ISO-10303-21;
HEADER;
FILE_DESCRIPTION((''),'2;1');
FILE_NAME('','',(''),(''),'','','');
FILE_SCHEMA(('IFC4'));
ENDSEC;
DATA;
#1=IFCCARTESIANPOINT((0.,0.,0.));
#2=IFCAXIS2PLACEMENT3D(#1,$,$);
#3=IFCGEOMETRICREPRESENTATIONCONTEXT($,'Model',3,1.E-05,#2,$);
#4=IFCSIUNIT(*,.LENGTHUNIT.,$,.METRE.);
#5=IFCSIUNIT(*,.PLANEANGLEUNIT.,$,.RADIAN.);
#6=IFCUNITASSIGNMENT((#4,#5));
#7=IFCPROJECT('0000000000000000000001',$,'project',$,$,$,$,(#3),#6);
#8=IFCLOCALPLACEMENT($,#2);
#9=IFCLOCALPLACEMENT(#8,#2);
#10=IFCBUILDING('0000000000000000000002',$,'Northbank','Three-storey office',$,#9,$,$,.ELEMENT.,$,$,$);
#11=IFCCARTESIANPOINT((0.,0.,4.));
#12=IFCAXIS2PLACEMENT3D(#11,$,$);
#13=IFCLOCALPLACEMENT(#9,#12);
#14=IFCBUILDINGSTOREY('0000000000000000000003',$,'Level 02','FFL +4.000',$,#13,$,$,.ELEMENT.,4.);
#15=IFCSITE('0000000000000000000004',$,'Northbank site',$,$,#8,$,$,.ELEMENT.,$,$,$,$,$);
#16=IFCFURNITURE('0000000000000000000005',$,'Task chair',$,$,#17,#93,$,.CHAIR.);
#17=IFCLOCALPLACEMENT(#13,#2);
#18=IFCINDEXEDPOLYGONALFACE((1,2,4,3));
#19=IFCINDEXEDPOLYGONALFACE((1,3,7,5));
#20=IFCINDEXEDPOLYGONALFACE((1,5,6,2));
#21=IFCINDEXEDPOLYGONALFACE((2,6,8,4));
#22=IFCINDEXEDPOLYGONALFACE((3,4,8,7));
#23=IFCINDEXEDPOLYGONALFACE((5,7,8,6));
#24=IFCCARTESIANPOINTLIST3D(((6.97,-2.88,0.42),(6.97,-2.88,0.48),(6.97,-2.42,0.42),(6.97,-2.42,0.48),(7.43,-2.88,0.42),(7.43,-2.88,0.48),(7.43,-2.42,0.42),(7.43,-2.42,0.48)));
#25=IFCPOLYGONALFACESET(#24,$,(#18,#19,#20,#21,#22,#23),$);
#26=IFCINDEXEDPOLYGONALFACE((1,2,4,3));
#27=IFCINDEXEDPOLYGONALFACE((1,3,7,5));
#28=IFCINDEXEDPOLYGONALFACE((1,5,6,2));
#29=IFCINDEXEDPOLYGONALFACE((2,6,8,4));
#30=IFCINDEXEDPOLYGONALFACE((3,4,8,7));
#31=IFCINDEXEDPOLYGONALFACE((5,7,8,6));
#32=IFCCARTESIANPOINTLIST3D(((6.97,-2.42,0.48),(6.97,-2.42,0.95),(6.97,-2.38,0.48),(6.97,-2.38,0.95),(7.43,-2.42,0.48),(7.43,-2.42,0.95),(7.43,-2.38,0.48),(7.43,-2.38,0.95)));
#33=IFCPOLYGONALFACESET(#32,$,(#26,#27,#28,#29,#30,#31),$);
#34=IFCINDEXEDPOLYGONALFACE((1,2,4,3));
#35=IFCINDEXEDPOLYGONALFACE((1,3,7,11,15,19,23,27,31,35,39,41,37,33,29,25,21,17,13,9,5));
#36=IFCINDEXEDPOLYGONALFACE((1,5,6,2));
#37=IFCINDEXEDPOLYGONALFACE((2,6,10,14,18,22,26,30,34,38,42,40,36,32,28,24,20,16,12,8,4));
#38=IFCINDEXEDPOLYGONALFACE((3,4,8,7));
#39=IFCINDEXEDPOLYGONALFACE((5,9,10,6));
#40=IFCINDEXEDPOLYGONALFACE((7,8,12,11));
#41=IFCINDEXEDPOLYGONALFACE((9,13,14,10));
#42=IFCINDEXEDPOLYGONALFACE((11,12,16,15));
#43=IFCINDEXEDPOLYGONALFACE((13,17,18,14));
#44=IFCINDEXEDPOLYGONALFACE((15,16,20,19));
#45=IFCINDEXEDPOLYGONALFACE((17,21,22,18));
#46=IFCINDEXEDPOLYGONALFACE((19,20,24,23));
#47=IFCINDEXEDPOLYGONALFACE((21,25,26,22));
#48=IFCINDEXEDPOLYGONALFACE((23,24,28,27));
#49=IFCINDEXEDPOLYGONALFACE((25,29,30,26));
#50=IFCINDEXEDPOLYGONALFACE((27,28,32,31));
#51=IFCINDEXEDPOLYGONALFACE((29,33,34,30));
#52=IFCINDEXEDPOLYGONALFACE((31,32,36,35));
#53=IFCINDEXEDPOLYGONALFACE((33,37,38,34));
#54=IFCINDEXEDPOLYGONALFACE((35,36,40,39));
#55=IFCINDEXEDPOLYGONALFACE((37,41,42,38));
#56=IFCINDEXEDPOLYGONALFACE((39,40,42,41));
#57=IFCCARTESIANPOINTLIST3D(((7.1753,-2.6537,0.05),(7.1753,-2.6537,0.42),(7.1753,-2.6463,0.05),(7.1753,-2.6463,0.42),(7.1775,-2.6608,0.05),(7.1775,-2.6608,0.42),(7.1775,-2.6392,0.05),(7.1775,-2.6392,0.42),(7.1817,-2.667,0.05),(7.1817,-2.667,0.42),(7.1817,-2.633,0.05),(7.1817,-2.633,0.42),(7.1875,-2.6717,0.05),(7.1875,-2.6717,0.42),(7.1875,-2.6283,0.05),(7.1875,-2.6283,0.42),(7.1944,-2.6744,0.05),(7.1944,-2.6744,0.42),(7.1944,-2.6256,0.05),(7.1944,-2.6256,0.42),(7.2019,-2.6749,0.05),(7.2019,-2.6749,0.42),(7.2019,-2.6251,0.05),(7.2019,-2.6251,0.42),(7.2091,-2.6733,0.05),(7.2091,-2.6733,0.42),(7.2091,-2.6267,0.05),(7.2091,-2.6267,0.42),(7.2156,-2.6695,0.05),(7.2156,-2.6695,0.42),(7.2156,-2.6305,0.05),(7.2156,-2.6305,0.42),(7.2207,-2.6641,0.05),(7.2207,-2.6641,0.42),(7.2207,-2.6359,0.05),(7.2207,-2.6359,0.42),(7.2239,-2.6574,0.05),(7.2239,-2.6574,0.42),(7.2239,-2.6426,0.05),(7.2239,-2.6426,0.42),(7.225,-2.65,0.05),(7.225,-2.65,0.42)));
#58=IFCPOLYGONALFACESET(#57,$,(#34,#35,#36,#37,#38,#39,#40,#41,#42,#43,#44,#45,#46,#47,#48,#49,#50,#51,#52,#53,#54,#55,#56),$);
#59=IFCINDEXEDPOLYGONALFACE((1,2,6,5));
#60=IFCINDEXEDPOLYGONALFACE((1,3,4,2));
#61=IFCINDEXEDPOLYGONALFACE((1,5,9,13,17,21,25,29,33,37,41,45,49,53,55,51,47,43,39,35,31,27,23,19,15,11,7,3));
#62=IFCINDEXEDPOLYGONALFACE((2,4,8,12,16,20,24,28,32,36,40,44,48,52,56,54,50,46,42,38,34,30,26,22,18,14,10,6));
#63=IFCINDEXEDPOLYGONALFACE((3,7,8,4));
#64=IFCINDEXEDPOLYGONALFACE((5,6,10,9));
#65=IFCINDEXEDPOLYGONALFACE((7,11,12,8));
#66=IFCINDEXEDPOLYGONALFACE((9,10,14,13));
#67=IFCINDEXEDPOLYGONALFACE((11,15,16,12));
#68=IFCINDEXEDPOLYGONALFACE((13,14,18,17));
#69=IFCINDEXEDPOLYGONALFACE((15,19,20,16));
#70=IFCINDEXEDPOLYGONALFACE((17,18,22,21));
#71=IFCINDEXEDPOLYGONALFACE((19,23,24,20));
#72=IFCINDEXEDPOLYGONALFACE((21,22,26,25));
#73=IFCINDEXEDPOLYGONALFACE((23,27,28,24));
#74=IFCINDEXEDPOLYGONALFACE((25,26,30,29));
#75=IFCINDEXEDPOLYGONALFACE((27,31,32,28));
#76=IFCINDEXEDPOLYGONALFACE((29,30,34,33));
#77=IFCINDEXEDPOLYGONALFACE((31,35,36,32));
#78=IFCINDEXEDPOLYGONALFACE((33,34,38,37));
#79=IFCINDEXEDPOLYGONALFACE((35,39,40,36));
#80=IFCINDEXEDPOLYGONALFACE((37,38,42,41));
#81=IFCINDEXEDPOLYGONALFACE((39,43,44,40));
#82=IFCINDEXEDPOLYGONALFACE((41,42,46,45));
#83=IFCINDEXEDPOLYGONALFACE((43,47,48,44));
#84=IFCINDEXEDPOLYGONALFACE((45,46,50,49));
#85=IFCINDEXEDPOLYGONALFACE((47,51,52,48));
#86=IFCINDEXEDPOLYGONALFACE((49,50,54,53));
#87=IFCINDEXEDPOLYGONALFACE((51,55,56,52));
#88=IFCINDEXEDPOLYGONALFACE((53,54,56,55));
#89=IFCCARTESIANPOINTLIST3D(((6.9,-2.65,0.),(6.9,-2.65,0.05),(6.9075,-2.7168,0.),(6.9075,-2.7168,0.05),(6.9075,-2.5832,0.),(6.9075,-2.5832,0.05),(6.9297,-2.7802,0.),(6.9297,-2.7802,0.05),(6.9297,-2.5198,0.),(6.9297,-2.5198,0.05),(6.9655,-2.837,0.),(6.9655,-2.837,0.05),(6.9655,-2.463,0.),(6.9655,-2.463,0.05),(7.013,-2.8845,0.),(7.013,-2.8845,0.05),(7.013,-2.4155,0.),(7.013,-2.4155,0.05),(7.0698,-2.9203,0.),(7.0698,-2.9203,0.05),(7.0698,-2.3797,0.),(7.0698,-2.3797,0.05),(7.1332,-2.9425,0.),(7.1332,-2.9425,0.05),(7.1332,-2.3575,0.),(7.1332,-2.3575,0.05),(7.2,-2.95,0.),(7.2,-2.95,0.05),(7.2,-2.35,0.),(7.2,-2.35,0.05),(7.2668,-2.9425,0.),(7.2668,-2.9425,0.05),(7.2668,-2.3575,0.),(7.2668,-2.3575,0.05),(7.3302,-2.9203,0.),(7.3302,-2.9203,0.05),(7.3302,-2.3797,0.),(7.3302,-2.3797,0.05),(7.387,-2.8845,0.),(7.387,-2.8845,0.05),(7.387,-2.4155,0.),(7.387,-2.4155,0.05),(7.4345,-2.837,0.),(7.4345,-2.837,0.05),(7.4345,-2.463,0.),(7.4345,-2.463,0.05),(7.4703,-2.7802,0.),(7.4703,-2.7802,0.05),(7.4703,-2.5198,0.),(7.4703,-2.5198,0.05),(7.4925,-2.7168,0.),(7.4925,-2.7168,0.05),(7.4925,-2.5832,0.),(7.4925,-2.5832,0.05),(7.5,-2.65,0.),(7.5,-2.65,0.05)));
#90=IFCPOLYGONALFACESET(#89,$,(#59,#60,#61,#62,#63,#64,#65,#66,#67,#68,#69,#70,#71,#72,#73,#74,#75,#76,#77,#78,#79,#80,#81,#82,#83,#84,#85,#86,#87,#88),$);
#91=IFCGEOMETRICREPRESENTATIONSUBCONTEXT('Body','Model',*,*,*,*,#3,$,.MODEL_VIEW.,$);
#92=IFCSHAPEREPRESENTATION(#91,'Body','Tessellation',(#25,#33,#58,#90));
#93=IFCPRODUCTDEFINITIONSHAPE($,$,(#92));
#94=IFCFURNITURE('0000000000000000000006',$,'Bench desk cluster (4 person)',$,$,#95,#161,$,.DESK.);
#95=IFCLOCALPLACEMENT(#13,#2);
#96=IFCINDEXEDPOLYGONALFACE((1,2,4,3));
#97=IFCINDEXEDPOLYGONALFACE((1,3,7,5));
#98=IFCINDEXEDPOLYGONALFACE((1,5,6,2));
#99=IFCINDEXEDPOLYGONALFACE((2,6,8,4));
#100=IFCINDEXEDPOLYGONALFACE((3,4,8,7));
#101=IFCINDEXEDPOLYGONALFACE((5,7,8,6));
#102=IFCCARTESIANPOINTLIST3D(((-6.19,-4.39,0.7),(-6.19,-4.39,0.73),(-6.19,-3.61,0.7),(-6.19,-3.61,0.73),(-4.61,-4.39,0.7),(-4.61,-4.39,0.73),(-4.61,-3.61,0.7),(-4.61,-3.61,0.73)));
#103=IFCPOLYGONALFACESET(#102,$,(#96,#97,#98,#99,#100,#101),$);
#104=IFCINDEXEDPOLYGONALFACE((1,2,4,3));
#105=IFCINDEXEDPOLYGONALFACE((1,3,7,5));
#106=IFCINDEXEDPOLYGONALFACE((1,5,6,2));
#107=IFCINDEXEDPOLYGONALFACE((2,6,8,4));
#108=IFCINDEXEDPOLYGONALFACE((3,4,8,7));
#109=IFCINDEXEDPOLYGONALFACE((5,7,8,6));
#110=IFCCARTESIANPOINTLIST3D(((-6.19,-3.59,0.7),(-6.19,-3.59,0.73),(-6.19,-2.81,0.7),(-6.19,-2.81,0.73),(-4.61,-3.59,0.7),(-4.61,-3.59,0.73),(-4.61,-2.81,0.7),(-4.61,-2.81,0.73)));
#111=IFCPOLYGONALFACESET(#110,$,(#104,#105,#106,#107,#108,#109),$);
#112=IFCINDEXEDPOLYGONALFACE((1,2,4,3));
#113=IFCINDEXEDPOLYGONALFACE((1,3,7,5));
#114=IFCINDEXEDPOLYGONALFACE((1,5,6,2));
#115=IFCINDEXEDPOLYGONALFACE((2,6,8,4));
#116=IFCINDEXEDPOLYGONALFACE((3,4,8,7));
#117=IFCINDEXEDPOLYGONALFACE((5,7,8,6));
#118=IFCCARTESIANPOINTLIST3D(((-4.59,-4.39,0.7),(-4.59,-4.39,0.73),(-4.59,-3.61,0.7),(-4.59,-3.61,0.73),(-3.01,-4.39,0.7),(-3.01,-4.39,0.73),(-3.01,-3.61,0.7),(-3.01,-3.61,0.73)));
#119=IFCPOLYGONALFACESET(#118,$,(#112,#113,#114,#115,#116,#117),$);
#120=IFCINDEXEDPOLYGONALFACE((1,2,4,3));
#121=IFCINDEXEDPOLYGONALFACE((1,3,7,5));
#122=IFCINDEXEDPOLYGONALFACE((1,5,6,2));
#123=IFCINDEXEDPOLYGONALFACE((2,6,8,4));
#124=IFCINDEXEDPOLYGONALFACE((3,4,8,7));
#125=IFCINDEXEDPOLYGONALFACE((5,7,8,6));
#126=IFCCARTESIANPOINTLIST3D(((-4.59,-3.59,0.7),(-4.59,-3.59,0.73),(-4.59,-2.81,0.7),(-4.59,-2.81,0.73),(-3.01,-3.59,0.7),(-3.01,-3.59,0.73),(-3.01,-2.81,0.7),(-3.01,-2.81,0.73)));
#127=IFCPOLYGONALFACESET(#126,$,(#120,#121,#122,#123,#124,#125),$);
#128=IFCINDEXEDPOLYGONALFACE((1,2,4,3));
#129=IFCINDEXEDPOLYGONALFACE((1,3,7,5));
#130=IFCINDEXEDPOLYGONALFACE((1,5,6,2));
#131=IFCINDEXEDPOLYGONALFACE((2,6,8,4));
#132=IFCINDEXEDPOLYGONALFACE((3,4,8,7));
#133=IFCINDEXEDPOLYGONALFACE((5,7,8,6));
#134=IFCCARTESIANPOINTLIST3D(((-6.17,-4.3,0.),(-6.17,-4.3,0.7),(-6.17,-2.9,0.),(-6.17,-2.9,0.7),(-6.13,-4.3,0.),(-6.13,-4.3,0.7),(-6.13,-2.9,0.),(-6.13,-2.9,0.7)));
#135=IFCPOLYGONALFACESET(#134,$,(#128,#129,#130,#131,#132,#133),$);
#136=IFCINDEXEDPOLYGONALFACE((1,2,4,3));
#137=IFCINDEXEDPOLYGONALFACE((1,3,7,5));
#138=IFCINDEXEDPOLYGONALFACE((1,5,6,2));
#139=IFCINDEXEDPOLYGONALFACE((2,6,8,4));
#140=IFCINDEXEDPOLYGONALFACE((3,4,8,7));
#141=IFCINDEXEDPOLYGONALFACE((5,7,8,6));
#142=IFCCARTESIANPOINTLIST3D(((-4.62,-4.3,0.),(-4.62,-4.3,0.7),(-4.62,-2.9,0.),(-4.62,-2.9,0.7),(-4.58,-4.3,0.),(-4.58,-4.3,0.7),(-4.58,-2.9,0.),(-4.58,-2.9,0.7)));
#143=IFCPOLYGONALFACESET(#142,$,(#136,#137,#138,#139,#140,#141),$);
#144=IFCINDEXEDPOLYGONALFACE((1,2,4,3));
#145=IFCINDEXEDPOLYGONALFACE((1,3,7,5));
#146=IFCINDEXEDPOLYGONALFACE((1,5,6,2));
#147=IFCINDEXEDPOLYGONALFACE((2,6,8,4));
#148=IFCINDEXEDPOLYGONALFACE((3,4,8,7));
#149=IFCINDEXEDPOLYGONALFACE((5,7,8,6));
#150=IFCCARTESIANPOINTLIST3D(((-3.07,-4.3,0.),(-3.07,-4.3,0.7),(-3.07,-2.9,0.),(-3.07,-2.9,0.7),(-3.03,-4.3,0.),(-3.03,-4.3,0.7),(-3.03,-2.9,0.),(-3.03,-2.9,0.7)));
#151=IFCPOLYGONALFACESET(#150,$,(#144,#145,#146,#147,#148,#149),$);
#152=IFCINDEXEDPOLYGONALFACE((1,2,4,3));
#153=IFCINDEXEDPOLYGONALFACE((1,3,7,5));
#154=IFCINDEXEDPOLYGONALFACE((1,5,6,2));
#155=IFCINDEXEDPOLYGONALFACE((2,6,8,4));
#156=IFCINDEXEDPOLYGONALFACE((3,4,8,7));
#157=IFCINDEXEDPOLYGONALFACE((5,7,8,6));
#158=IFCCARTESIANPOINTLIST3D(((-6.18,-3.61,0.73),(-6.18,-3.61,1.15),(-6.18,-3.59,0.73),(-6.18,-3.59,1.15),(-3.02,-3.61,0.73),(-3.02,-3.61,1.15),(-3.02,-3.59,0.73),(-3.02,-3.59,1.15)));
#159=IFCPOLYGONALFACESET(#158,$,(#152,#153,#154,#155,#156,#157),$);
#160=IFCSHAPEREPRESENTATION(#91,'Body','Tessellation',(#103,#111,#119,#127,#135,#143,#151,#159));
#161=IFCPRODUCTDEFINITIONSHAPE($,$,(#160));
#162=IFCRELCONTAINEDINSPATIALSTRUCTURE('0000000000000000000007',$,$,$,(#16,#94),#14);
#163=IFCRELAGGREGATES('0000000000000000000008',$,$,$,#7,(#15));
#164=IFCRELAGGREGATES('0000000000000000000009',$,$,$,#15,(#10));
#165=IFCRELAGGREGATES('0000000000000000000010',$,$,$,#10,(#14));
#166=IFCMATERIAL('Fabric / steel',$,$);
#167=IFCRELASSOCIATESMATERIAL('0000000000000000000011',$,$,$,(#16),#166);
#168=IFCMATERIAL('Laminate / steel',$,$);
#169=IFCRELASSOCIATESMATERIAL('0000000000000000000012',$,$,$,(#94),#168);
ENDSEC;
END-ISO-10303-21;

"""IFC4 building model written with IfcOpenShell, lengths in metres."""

from ifc_helpers import new_model, si_unit, frame, origin, place, context, subcontext, project, spatial, rectangle, circle, extrude, material, element, save


model = new_model("IFC4")

# Units and contexts
model_context = context("Model", 3, precision=1e-05, world=origin())
body_context = subcontext(model_context, "Body", "Model", "MODEL_VIEW")
ifc_project = project(units=[si_unit("LENGTHUNIT", "METRE"), si_unit("PLANEANGLEUNIT", "RADIAN")], contexts=[model_context])

# Site, building, storey
site_placement = place(None, origin())
site = spatial("IfcSite", under=ifc_project, at=site_placement, Name="Northbank site", CompositionType="ELEMENT")
building_placement = place(site_placement, origin())
building = spatial("IfcBuilding", under=site, at=building_placement, Name="Northbank", Description="Three-storey office", CompositionType="ELEMENT")
storey_placement = place(building_placement, frame((0.0, 0.0, 4.0)))
storey = spatial("IfcBuildingStorey", under=building, at=storey_placement, Name="Level 02", Description="FFL +4.000", CompositionType="ELEMENT", Elevation=4.0)

# Furniture
ifc_material_1 = material(Name="Fabric / steel")
ifc_material_2 = material(Name="Laminate / steel")
furniture_1_placement = place(storey_placement, frame((0.0, 0.0, -4.0)))
element("IfcFurniture", 1, at=furniture_1_placement, inside=storey, material=ifc_material_1, Name="Task chair", PredefinedType="CHAIR", context=body_context, shape_type="SweptSolid", body=[
    extrude(rectangle(XDim=0.46, YDim=0.46), frame((7.2, -2.65, 4.42)), (0.0, 0.0, 1.0), 0.06),
    extrude(rectangle(XDim=0.46, YDim=0.04), frame((7.2, -2.4, 4.48)), (0.0, 0.0, 1.0), 0.47),
    extrude(circle(Radius=0.025), frame((7.2, -2.65, 4.05), z_axis=(0.0, 0.0, 1.0), x_axis=(1.0, 0.0, 0.0)), (0.0, 0.0, 1.0), 0.37),
    extrude(circle(Radius=0.3), frame((7.2, -2.65, 4.0), z_axis=(0.0, 0.0, 1.0), x_axis=(1.0, 0.0, 0.0)), (0.0, 0.0, 1.0), 0.05),
])
furniture_2_placement = place(storey_placement, frame((0.0, 0.0, -4.0)))
element("IfcFurniture", 2, at=furniture_2_placement, inside=storey, material=ifc_material_2, Name="Bench desk cluster (4 person)", PredefinedType="DESK", context=body_context, shape_type="SweptSolid", body=[
    extrude(rectangle(XDim=1.58, YDim=0.78), frame((-5.4, -4.0, 4.7)), (0.0, 0.0, 1.0), 0.03),
    extrude(rectangle(XDim=1.58, YDim=0.78), frame((-5.4, -3.2, 4.7)), (0.0, 0.0, 1.0), 0.03),
    extrude(rectangle(XDim=1.58, YDim=0.78), frame((-3.8, -4.0, 4.7)), (0.0, 0.0, 1.0), 0.03),
    extrude(rectangle(XDim=1.58, YDim=0.78), frame((-3.8, -3.2, 4.7)), (0.0, 0.0, 1.0), 0.03),
    extrude(rectangle(XDim=0.04, YDim=1.4), frame((-6.15, -3.6, 4.0)), (0.0, 0.0, 1.0), 0.7),
    extrude(rectangle(XDim=0.04, YDim=1.4), frame((-4.6, -3.6, 4.0)), (0.0, 0.0, 1.0), 0.7),
    extrude(rectangle(XDim=0.04, YDim=1.4), frame((-3.05, -3.6, 4.0)), (0.0, 0.0, 1.0), 0.7),
    extrude(rectangle(XDim=3.16, YDim=0.02), frame((-4.6, -3.6, 4.73)), (0.0, 0.0, 1.0), 0.42),
])

save(model, "model.ifc")
